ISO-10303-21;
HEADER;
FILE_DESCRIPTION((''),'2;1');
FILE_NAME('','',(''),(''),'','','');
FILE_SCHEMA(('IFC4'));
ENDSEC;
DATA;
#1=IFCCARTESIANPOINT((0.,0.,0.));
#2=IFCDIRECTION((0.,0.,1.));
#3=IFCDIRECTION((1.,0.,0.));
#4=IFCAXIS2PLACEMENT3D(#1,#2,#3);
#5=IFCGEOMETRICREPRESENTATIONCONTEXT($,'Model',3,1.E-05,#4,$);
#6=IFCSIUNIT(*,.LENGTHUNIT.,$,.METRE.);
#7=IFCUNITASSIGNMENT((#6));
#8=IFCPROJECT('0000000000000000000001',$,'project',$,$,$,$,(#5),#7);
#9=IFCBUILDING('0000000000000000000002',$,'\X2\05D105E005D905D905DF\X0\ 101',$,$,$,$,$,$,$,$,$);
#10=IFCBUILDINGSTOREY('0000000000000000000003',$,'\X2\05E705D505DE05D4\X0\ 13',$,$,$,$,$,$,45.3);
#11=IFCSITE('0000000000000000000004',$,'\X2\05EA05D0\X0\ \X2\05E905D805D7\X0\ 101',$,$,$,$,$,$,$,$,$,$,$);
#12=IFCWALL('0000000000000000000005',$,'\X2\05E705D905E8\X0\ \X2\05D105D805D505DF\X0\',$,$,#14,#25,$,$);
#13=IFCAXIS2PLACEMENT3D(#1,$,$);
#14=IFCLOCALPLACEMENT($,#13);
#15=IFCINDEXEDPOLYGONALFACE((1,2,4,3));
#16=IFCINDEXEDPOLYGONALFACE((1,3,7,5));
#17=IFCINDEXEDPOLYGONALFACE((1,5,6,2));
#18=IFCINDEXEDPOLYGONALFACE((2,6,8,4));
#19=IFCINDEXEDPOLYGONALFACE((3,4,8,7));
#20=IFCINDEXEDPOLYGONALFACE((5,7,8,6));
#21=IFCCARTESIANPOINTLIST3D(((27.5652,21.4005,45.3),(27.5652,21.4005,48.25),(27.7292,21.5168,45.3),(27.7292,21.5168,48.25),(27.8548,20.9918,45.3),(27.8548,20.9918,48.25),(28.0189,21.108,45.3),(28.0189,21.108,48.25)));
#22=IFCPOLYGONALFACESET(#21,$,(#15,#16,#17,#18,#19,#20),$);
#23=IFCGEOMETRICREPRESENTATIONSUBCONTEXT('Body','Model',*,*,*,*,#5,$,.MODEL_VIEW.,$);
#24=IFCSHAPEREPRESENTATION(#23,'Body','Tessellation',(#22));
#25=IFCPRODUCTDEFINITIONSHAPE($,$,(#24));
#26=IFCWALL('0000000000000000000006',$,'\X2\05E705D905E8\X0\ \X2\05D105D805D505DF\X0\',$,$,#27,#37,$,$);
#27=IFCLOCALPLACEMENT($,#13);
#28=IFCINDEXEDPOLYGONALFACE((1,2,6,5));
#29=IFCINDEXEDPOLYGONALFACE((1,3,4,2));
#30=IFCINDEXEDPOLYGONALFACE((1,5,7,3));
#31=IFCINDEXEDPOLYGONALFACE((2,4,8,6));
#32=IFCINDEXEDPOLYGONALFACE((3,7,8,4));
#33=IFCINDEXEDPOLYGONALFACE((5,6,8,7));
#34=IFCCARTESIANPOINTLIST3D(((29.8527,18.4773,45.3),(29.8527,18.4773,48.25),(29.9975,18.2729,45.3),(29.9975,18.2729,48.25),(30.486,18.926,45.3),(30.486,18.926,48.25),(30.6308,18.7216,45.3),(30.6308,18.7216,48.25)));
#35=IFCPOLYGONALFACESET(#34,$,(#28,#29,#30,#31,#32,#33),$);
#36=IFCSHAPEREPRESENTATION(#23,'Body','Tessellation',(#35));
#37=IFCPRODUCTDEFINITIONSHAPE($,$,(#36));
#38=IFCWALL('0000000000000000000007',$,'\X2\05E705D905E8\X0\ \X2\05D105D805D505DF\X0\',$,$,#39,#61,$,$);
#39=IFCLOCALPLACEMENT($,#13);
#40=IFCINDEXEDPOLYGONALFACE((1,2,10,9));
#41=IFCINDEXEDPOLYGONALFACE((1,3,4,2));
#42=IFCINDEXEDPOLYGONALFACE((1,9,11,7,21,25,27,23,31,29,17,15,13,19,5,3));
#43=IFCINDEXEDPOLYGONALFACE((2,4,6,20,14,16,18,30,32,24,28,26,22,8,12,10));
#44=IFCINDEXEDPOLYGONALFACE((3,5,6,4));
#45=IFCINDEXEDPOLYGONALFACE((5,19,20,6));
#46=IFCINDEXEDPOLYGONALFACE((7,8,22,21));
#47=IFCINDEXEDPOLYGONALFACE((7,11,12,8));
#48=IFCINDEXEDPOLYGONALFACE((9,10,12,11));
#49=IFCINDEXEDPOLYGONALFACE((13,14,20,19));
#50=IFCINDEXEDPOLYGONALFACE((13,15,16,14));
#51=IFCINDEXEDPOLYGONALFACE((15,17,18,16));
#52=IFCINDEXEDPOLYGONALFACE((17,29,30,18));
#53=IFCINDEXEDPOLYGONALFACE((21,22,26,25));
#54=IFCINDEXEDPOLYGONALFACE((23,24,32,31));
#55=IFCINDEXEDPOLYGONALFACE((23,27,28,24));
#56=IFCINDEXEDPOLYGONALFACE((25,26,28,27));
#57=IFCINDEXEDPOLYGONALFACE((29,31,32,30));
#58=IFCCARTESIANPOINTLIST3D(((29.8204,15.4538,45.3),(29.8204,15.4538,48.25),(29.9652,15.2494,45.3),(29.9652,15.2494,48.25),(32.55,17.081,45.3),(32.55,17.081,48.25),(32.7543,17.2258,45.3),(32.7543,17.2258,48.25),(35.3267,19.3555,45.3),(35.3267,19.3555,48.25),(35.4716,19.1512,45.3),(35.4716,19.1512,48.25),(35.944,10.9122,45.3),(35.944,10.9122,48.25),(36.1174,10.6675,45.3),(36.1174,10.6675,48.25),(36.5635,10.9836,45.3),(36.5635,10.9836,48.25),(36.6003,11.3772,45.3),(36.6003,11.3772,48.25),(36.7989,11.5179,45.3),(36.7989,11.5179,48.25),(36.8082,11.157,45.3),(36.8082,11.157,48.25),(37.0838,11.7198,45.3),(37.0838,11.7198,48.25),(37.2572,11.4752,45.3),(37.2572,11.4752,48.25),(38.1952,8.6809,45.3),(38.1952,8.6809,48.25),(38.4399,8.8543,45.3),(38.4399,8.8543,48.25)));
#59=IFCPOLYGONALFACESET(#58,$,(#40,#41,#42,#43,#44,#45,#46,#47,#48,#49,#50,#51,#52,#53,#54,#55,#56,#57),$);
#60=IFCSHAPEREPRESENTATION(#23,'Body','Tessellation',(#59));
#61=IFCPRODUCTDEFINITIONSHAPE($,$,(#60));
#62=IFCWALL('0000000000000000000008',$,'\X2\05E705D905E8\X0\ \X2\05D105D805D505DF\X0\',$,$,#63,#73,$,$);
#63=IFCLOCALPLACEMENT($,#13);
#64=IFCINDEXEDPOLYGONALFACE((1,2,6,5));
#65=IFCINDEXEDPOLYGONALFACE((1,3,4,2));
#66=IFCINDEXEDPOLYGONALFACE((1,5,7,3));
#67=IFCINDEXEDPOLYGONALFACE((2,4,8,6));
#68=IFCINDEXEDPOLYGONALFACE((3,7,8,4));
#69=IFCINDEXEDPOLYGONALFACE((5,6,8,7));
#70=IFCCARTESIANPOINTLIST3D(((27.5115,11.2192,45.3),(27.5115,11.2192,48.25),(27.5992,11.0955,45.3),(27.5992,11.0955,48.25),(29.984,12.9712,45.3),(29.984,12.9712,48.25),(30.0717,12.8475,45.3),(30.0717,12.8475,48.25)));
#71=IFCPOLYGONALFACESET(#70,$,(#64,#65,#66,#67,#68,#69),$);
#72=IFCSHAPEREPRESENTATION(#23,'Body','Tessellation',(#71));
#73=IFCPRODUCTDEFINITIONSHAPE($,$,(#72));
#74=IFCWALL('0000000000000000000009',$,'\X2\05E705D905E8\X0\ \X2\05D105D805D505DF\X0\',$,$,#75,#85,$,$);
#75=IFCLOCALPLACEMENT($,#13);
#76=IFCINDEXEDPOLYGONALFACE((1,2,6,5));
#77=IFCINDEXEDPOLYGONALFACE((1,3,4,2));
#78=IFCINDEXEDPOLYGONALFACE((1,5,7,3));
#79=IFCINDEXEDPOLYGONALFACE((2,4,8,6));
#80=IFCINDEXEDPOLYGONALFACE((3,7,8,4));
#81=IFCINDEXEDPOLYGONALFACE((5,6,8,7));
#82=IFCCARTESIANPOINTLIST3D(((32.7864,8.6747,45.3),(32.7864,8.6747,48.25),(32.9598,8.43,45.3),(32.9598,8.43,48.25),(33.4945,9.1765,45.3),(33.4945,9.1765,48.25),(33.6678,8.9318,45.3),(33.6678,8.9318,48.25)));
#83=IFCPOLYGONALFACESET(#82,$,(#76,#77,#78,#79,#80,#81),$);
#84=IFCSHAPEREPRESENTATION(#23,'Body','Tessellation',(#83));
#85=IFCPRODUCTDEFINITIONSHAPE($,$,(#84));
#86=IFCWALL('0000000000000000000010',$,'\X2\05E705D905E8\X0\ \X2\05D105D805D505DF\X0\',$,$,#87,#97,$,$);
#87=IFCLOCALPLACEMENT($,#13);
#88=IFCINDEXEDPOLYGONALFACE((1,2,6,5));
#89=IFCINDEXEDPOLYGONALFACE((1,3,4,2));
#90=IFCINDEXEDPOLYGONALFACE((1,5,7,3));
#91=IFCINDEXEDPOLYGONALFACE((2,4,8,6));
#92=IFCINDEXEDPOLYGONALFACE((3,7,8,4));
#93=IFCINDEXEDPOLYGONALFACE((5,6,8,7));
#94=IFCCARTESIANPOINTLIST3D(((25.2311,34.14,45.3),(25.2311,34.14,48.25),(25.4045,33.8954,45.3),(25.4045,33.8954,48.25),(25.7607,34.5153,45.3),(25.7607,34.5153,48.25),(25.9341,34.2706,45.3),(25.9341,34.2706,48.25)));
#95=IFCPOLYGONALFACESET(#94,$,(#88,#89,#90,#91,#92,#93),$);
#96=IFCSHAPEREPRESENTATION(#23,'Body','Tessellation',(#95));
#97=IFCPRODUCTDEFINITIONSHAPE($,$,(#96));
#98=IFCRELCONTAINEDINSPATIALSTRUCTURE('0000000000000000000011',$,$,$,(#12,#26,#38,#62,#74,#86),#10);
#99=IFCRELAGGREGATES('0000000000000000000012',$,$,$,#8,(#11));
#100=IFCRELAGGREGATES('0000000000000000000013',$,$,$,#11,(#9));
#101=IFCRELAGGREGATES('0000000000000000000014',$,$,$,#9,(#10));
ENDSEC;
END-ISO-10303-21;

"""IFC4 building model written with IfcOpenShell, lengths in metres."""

from ifc_helpers import new_model, si_unit, frame, origin_with_axes, context, subcontext, project, spatial, polyline, outline, extrude, element, save


model = new_model("IFC4")

# Units and contexts
model_context = context("Model", 3, precision=1e-05, world=origin_with_axes())
body_context = subcontext(model_context, "Body", "Model", "MODEL_VIEW")
ifc_project = project(units=[si_unit("LENGTHUNIT", "METRE")], contexts=[model_context])

# Site, building, storey
site = spatial("IfcSite", under=ifc_project, Name="תא שטח 101")
building = spatial("IfcBuilding", under=site, Name="בניין 101")
storey = spatial("IfcBuildingStorey", under=building, Name="קומה 13", Elevation=45.3)

# Walls
element("IfcWall", 1, inside=storey, Name="קיר בטון", context=body_context, shape_type="SweptSolid", body=[
    extrude(outline(polyline([(27.8548, 20.9918), (28.0189, 21.108), (27.7292, 21.5168), (27.5652, 21.4005), (27.8548, 20.9918)])), frame((0.0, 0.0, 45.3)), (0.0, 0.0, 1.0), 2.95),
])
element("IfcWall", 2, inside=storey, Name="קיר בטון", context=body_context, shape_type="SweptSolid", body=[
    extrude(outline(polyline([(29.8527, 18.4773), (29.9975, 18.2729), (30.6308, 18.7216), (30.486, 18.926), (29.8527, 18.4773)])), frame((0.0, 0.0, 45.3)), (0.0, 0.0, 1.0), 2.95),
])
element("IfcWall", 3, inside=storey, Name="קיר בטון", context=body_context, shape_type="SweptSolid", body=[
    extrude(outline(polyline([(29.8204, 15.4538), (29.9652, 15.2494), (32.55, 17.081), (36.6003, 11.3772), (35.944, 10.9122), (36.1174, 10.6675), (36.5635, 10.9836), (38.1952, 8.6809), (38.4399, 8.8543), (36.8082, 11.157), (37.2572, 11.4752), (37.0838, 11.7198), (36.7989, 11.5179), (32.7543, 17.2258), (35.4716, 19.1512), (35.3267, 19.3555), (29.8204, 15.4538)])), frame((0.0, 0.0, 45.3)), (0.0, 0.0, 1.0), 2.95),
])
element("IfcWall", 4, inside=storey, Name="קיר בטון", context=body_context, shape_type="SweptSolid", body=[
    extrude(outline(polyline([(30.0717, 12.8475), (29.984, 12.9712), (27.5115, 11.2192), (27.5992, 11.0955), (30.0717, 12.8475)])), frame((0.0, 0.0, 45.3)), (0.0, 0.0, 1.0), 2.95),
])
element("IfcWall", 5, inside=storey, Name="קיר בטון", context=body_context, shape_type="SweptSolid", body=[
    extrude(outline(polyline([(32.7864, 8.6747), (32.9598, 8.43), (33.6678, 8.9318), (33.4945, 9.1765), (32.7864, 8.6747)])), frame((0.0, 0.0, 45.3)), (0.0, 0.0, 1.0), 2.95),
])
element("IfcWall", 6, inside=storey, Name="קיר בטון", context=body_context, shape_type="SweptSolid", body=[
    extrude(outline(polyline([(25.7607, 34.5153), (25.2311, 34.14), (25.4045, 33.8954), (25.9341, 34.2706), (25.7607, 34.5153)])), frame((0.0, 0.0, 45.3)), (0.0, 0.0, 1.0), 2.95),
])

save(model, "model.ifc")
